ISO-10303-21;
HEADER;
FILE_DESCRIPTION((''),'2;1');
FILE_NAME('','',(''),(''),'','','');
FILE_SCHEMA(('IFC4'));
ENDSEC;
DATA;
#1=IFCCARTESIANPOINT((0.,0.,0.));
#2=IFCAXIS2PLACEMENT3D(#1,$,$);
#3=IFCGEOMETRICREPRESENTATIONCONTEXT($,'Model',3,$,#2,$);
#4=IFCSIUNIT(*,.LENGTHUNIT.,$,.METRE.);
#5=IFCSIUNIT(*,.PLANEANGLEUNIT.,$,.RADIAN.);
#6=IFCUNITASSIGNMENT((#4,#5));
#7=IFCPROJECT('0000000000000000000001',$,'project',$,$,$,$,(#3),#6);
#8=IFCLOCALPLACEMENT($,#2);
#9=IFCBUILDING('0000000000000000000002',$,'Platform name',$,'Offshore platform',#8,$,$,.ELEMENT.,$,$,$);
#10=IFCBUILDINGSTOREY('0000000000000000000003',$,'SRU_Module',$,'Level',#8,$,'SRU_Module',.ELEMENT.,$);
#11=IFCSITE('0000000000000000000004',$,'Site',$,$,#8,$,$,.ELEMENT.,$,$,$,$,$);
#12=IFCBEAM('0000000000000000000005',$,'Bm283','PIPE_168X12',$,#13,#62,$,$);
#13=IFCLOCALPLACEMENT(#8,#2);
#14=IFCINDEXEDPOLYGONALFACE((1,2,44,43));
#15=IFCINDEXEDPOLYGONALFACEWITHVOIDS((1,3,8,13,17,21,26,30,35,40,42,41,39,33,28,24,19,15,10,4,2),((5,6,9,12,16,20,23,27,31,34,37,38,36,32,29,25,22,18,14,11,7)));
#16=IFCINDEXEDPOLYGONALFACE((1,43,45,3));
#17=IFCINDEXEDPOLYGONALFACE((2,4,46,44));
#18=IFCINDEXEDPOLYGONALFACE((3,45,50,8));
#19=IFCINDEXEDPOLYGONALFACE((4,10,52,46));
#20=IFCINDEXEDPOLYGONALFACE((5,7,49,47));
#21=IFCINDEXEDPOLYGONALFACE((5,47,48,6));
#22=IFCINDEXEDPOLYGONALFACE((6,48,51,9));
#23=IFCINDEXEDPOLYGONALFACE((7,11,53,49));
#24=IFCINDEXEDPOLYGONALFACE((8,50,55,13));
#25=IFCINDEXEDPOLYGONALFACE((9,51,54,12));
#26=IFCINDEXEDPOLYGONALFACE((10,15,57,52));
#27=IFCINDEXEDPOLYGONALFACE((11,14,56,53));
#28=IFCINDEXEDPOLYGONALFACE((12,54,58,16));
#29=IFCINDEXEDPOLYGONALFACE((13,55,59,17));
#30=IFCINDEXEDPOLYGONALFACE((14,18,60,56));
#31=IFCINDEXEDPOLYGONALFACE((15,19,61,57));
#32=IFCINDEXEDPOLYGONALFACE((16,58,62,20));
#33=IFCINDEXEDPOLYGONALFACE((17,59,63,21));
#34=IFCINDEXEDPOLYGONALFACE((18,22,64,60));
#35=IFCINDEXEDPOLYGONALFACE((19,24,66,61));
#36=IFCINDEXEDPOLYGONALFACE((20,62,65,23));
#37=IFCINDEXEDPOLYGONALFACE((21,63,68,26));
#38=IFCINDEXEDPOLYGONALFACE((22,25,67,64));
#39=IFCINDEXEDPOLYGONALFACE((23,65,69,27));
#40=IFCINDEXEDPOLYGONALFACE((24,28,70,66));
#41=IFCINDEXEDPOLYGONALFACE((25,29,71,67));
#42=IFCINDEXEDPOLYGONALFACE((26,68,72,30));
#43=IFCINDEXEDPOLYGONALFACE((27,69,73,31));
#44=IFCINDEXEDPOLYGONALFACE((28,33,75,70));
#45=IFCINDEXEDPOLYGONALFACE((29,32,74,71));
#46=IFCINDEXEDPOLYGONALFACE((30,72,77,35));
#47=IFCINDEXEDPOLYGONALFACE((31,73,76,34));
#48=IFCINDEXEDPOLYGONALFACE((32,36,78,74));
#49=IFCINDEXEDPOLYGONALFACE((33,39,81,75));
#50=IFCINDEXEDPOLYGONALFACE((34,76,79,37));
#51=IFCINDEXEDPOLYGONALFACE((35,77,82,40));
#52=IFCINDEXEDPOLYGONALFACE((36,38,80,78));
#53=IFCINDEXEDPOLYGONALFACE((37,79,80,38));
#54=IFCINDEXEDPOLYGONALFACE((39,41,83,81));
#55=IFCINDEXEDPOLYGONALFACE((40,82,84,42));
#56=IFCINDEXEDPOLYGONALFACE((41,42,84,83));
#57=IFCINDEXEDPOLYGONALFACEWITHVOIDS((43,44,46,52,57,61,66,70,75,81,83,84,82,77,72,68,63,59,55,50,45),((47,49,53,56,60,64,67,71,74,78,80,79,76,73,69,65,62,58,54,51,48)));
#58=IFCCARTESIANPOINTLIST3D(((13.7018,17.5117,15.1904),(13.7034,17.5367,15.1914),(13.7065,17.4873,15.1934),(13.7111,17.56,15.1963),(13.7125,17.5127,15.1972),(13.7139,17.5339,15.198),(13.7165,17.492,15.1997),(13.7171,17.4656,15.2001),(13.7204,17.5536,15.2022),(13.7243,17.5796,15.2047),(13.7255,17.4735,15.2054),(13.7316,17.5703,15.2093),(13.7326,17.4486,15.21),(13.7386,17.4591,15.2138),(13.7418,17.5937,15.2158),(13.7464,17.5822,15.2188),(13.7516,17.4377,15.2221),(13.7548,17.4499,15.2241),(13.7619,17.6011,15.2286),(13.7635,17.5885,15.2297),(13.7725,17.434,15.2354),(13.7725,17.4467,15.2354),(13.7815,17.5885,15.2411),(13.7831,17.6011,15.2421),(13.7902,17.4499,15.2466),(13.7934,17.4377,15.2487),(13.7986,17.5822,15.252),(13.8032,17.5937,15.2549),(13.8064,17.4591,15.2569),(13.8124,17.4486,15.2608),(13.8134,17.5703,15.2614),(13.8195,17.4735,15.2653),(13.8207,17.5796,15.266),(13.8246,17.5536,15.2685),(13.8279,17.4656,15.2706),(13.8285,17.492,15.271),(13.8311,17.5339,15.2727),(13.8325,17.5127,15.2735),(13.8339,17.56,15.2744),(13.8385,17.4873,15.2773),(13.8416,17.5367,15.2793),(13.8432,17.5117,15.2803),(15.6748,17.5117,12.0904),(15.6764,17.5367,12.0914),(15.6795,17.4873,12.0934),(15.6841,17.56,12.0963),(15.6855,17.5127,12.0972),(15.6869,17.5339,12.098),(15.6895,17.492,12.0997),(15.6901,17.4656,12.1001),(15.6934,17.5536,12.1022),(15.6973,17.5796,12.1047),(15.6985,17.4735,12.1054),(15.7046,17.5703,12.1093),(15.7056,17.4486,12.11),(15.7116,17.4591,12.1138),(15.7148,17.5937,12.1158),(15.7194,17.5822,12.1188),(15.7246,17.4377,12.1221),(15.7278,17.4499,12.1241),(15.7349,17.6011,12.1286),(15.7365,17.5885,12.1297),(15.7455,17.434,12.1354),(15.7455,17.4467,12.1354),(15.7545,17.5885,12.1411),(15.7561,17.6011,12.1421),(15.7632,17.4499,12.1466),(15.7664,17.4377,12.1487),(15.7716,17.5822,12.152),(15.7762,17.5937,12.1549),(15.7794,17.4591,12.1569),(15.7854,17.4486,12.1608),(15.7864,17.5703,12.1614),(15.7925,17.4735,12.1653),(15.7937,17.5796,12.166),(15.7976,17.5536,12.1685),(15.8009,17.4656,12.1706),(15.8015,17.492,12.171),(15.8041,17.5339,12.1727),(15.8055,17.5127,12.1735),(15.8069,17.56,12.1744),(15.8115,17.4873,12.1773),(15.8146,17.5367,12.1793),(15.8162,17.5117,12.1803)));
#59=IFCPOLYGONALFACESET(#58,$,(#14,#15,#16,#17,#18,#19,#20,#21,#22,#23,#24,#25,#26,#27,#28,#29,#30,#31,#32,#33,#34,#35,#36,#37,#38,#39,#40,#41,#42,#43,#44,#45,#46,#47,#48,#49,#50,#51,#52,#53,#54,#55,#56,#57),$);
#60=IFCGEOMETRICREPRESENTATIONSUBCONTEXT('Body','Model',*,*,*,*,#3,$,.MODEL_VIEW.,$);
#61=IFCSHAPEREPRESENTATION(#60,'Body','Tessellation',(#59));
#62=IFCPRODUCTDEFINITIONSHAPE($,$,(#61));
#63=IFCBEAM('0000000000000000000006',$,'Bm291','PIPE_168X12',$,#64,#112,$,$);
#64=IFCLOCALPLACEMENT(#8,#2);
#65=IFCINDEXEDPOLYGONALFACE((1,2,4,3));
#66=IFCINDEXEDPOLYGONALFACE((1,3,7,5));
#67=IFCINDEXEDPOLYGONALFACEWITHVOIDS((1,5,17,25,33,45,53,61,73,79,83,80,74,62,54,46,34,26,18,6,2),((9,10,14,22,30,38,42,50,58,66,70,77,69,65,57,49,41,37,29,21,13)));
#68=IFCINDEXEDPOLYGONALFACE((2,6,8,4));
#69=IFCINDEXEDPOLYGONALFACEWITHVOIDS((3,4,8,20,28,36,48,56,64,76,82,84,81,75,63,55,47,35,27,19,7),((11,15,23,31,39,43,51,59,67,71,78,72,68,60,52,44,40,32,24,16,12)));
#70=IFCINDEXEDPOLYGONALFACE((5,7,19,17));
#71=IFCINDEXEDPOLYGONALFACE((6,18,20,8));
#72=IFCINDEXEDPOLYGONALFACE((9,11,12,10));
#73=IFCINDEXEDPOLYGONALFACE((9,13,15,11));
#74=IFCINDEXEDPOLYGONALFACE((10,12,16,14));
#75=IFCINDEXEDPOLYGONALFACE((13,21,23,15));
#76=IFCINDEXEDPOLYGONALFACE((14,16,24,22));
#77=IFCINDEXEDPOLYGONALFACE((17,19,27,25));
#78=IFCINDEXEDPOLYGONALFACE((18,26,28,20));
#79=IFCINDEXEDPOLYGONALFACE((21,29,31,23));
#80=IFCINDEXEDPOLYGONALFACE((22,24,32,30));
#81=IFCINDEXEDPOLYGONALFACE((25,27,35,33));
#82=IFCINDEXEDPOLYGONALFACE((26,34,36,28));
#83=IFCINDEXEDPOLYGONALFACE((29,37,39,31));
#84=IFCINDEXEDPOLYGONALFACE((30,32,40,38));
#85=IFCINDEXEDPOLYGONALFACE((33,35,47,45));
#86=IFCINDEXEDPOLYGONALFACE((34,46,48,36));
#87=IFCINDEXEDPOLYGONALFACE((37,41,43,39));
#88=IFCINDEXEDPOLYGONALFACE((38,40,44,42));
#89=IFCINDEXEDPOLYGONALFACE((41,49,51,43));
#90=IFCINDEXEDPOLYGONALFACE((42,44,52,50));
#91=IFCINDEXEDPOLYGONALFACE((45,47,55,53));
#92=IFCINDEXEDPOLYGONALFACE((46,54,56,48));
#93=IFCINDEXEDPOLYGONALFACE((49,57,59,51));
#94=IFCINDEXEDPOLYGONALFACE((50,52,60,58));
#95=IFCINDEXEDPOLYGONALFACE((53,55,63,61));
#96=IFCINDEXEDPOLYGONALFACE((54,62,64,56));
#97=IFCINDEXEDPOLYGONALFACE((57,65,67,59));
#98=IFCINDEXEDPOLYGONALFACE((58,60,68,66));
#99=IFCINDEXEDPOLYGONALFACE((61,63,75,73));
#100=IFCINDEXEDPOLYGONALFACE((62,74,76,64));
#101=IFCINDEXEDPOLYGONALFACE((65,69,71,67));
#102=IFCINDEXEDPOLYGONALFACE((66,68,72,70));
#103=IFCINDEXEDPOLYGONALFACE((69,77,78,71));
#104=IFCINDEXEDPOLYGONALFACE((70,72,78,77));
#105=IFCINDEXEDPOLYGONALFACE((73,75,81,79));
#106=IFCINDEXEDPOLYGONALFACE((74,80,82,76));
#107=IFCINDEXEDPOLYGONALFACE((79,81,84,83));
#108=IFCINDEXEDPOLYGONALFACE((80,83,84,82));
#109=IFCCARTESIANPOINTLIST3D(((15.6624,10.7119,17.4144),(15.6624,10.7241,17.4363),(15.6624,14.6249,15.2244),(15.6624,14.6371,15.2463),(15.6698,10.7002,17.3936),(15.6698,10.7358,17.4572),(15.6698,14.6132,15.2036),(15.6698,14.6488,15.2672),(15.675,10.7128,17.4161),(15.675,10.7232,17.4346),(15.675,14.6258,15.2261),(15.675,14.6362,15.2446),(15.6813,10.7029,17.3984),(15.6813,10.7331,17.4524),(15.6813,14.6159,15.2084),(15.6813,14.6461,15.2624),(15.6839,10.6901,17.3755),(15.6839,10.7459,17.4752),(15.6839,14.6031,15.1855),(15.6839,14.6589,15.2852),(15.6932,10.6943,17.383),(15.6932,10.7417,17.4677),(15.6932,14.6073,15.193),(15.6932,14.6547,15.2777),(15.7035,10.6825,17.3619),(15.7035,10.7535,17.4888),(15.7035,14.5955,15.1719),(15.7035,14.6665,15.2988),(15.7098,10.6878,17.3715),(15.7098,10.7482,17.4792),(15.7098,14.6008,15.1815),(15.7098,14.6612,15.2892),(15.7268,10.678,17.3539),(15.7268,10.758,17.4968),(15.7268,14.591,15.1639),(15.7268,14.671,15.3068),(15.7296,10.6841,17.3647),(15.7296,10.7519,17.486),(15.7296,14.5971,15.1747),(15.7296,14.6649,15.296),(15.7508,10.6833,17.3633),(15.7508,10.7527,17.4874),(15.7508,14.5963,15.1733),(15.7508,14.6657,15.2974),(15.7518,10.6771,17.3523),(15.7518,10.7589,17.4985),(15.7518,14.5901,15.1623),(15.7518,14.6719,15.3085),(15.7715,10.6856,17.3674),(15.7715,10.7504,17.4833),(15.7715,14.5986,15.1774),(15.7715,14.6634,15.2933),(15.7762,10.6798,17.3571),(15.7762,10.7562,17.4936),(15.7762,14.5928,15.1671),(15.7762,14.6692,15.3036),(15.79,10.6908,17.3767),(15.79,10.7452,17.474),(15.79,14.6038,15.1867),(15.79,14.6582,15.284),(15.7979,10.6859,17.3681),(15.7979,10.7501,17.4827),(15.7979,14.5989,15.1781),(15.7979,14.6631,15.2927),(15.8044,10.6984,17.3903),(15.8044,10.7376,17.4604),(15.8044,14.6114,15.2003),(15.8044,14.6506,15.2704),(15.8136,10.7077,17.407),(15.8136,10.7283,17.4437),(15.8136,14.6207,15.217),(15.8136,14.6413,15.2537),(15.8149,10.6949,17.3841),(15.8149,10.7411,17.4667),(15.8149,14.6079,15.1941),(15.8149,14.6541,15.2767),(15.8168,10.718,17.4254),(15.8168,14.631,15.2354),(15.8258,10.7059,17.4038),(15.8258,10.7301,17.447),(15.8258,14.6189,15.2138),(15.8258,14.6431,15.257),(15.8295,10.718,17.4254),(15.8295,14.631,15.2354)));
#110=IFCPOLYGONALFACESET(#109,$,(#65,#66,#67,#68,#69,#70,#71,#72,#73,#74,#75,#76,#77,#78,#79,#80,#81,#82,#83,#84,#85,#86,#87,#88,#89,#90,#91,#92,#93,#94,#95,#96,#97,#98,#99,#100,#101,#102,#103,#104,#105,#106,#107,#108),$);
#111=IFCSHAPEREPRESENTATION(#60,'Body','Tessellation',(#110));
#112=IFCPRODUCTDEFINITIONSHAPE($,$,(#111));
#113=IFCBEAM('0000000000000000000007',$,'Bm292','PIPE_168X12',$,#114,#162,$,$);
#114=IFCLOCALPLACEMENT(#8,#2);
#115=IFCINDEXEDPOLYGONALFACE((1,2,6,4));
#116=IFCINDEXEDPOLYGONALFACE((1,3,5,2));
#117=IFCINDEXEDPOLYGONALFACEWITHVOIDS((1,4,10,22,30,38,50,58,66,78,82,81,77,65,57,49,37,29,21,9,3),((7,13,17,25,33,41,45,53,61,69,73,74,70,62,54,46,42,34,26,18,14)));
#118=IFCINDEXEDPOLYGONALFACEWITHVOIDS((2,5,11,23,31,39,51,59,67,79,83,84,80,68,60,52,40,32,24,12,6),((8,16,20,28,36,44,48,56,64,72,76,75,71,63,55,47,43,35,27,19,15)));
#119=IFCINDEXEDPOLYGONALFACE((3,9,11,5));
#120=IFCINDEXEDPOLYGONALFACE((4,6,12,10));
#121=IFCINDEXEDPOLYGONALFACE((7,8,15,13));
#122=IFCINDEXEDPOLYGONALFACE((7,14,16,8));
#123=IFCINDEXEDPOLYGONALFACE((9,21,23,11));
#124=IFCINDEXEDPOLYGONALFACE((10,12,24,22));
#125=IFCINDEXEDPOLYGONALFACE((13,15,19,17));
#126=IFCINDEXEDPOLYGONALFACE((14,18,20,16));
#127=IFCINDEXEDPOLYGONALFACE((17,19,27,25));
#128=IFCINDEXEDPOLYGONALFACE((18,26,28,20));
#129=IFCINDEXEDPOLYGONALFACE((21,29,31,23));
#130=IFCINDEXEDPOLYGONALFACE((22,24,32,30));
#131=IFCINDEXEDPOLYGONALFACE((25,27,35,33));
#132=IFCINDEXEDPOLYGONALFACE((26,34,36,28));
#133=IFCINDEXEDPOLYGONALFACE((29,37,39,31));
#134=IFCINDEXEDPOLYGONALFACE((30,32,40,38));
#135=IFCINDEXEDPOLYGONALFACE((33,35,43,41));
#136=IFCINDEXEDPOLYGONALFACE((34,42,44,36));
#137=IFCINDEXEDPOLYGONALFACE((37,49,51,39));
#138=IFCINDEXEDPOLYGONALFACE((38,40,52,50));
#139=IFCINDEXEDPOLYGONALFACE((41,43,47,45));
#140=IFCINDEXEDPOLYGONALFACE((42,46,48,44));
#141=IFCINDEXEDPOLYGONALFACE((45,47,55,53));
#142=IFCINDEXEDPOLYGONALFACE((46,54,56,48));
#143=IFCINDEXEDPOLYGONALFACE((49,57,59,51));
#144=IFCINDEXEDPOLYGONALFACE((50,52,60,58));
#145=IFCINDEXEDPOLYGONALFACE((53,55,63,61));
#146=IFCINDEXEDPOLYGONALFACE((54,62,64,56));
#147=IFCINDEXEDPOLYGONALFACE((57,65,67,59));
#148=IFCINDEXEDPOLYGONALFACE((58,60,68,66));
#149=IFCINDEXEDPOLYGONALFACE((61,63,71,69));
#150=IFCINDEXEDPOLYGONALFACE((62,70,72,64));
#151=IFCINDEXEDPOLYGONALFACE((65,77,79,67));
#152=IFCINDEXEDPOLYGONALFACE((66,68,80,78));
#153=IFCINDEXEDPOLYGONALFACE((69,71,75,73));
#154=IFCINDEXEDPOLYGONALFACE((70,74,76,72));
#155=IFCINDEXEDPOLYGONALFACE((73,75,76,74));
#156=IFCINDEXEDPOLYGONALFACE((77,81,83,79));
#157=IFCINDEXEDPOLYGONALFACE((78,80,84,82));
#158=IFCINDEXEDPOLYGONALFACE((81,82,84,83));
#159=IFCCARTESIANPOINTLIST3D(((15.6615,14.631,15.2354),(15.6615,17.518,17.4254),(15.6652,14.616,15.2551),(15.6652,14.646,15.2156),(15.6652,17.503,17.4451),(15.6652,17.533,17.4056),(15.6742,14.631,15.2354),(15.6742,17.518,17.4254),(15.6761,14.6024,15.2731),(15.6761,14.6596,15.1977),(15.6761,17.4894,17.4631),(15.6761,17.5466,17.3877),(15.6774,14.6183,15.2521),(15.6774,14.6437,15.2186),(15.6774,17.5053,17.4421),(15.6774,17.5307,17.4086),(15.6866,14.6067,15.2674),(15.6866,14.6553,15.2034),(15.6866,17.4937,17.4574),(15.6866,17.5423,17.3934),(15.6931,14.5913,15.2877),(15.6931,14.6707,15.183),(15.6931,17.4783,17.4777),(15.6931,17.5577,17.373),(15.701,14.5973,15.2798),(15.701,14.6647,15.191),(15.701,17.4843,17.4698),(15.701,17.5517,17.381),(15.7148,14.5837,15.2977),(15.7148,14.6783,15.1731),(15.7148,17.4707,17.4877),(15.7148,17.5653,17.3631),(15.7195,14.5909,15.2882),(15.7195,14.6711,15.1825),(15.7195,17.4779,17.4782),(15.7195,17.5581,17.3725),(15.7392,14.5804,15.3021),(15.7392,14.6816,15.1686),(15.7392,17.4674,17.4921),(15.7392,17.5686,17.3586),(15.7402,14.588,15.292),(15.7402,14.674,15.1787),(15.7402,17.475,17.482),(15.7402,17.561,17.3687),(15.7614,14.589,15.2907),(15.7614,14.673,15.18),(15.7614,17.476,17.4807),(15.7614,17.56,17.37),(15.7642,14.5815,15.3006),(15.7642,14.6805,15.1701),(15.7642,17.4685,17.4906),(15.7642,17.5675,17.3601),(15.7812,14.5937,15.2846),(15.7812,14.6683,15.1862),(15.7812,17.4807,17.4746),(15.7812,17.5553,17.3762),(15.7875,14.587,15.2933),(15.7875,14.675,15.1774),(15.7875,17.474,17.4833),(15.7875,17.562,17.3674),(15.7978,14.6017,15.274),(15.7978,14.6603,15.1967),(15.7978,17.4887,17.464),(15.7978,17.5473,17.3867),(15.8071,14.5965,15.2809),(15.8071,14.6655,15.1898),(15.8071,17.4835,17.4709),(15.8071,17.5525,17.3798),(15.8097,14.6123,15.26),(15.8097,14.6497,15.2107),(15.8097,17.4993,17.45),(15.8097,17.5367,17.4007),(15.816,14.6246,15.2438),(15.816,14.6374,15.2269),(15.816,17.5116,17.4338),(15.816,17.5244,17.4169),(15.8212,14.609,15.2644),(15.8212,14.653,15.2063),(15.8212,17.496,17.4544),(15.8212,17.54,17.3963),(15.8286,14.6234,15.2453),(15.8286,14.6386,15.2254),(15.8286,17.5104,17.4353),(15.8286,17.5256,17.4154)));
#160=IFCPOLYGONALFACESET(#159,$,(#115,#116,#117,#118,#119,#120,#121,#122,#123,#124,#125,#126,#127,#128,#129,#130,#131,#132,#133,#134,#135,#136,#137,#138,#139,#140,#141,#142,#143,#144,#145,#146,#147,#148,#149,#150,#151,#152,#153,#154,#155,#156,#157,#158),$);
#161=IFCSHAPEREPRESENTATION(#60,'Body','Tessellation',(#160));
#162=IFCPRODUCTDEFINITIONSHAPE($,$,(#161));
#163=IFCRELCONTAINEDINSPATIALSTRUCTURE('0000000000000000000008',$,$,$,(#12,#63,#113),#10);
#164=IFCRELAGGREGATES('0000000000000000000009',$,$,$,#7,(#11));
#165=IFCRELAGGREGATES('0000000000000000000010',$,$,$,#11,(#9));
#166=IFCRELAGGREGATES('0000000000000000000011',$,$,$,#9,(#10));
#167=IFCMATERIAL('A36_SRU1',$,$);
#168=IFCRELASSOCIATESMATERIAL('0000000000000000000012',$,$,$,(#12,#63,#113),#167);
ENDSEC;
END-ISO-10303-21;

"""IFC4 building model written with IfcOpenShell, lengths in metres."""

from ifc_helpers import new_model, si_unit, frame, origin, origin_2d, place, context, subcontext, project, spatial, hollow_circle, extrude, source, transform, mapped, material, element, save


model = new_model("IFC4")

# Units and contexts
model_context = context("Model", 3, world=origin())
body_context = subcontext(model_context, "Body", "Model", "MODEL_VIEW")
ifc_project = project(units=[si_unit("LENGTHUNIT", "METRE"), si_unit("PLANEANGLEUNIT", "RADIAN")], contexts=[model_context])

# Site, building, storey
placement_1 = place(None, origin())
site = spatial("IfcSite", under=ifc_project, at=placement_1, Name="Site", CompositionType="ELEMENT")
building = spatial("IfcBuilding", under=site, at=placement_1, Name="Platform name", ObjectType="Offshore platform", CompositionType="ELEMENT")
storey = spatial("IfcBuildingStorey", under=building, at=placement_1, Name="SRU_Module", ObjectType="Level", LongName="SRU_Module", CompositionType="ELEMENT")

# Beams
ifc_material_1 = material(Name="A36_SRU1")
shared_shape_1 = source(origin(), body_context, "Body", "SweptSolid", [
    extrude(hollow_circle(Radius=0.084, WallThickness=0.0127, at=origin_2d()), frame((0.0, 0.0, 0.0), z_axis=(-0.536928, 0.0, 0.843628), x_axis=(0.0, -1.0, 0.0)), (0.0, 0.0, 1.0), 3.6746),
])
placement_2 = place(None, origin())
placement_3 = place(placement_2, origin())
placement_4 = place(placement_3, origin())
beam_1_placement = place(placement_4, frame((15.7455, 17.518, 12.1354)))
element("IfcBeam", 1, at=beam_1_placement, inside=storey, material=ifc_material_1, Name="Bm283", Description="PIPE_168X12", context=body_context, shape_type="MappedRepresentation", body=[
    mapped(shared_shape_1, transform((0.0, 0.0, 0.0), scale=1.0)),
])
shared_shape_2 = source(origin(), body_context, "Body", "SweptSolid", [
    extrude(hollow_circle(Radius=0.084, WallThickness=0.0127, at=origin_2d()), frame((0.0, 0.0, 0.0), z_axis=(0.0, -0.872628, 0.488386), x_axis=(1.0, 0.0, 0.0)), (0.0, 0.0, 1.0), 4.4842),
])
placement_5 = place(None, origin())
placement_6 = place(placement_5, origin())
placement_7 = place(placement_6, origin())
beam_2_placement = place(placement_7, frame((15.7455, 14.631, 15.2354)))
element("IfcBeam", 2, at=beam_2_placement, inside=storey, material=ifc_material_1, Name="Bm291", Description="PIPE_168X12", context=body_context, shape_type="MappedRepresentation", body=[
    mapped(shared_shape_2, transform((0.0, 0.0, 0.0), scale=1.0)),
])
shared_shape_3 = source(origin(), body_context, "Body", "SweptSolid", [
    extrude(hollow_circle(Radius=0.084, WallThickness=0.0127, at=origin_2d()), frame((0.0, 0.0, 0.0), z_axis=(0.0, 0.79671, 0.604362), x_axis=(-1.0, 0.0, 0.0)), (0.0, 0.0, 1.0), 3.6237),
])
placement_8 = place(None, origin())
placement_9 = place(placement_8, origin())
placement_10 = place(placement_9, origin())
beam_3_placement = place(placement_10, frame((15.7455, 14.631, 15.2354)))
element("IfcBeam", 3, at=beam_3_placement, inside=storey, material=ifc_material_1, Name="Bm292", Description="PIPE_168X12", context=body_context, shape_type="MappedRepresentation", body=[
    mapped(shared_shape_3, transform((0.0, 0.0, 0.0), scale=1.0)),
])

save(model, "model.ifc")
